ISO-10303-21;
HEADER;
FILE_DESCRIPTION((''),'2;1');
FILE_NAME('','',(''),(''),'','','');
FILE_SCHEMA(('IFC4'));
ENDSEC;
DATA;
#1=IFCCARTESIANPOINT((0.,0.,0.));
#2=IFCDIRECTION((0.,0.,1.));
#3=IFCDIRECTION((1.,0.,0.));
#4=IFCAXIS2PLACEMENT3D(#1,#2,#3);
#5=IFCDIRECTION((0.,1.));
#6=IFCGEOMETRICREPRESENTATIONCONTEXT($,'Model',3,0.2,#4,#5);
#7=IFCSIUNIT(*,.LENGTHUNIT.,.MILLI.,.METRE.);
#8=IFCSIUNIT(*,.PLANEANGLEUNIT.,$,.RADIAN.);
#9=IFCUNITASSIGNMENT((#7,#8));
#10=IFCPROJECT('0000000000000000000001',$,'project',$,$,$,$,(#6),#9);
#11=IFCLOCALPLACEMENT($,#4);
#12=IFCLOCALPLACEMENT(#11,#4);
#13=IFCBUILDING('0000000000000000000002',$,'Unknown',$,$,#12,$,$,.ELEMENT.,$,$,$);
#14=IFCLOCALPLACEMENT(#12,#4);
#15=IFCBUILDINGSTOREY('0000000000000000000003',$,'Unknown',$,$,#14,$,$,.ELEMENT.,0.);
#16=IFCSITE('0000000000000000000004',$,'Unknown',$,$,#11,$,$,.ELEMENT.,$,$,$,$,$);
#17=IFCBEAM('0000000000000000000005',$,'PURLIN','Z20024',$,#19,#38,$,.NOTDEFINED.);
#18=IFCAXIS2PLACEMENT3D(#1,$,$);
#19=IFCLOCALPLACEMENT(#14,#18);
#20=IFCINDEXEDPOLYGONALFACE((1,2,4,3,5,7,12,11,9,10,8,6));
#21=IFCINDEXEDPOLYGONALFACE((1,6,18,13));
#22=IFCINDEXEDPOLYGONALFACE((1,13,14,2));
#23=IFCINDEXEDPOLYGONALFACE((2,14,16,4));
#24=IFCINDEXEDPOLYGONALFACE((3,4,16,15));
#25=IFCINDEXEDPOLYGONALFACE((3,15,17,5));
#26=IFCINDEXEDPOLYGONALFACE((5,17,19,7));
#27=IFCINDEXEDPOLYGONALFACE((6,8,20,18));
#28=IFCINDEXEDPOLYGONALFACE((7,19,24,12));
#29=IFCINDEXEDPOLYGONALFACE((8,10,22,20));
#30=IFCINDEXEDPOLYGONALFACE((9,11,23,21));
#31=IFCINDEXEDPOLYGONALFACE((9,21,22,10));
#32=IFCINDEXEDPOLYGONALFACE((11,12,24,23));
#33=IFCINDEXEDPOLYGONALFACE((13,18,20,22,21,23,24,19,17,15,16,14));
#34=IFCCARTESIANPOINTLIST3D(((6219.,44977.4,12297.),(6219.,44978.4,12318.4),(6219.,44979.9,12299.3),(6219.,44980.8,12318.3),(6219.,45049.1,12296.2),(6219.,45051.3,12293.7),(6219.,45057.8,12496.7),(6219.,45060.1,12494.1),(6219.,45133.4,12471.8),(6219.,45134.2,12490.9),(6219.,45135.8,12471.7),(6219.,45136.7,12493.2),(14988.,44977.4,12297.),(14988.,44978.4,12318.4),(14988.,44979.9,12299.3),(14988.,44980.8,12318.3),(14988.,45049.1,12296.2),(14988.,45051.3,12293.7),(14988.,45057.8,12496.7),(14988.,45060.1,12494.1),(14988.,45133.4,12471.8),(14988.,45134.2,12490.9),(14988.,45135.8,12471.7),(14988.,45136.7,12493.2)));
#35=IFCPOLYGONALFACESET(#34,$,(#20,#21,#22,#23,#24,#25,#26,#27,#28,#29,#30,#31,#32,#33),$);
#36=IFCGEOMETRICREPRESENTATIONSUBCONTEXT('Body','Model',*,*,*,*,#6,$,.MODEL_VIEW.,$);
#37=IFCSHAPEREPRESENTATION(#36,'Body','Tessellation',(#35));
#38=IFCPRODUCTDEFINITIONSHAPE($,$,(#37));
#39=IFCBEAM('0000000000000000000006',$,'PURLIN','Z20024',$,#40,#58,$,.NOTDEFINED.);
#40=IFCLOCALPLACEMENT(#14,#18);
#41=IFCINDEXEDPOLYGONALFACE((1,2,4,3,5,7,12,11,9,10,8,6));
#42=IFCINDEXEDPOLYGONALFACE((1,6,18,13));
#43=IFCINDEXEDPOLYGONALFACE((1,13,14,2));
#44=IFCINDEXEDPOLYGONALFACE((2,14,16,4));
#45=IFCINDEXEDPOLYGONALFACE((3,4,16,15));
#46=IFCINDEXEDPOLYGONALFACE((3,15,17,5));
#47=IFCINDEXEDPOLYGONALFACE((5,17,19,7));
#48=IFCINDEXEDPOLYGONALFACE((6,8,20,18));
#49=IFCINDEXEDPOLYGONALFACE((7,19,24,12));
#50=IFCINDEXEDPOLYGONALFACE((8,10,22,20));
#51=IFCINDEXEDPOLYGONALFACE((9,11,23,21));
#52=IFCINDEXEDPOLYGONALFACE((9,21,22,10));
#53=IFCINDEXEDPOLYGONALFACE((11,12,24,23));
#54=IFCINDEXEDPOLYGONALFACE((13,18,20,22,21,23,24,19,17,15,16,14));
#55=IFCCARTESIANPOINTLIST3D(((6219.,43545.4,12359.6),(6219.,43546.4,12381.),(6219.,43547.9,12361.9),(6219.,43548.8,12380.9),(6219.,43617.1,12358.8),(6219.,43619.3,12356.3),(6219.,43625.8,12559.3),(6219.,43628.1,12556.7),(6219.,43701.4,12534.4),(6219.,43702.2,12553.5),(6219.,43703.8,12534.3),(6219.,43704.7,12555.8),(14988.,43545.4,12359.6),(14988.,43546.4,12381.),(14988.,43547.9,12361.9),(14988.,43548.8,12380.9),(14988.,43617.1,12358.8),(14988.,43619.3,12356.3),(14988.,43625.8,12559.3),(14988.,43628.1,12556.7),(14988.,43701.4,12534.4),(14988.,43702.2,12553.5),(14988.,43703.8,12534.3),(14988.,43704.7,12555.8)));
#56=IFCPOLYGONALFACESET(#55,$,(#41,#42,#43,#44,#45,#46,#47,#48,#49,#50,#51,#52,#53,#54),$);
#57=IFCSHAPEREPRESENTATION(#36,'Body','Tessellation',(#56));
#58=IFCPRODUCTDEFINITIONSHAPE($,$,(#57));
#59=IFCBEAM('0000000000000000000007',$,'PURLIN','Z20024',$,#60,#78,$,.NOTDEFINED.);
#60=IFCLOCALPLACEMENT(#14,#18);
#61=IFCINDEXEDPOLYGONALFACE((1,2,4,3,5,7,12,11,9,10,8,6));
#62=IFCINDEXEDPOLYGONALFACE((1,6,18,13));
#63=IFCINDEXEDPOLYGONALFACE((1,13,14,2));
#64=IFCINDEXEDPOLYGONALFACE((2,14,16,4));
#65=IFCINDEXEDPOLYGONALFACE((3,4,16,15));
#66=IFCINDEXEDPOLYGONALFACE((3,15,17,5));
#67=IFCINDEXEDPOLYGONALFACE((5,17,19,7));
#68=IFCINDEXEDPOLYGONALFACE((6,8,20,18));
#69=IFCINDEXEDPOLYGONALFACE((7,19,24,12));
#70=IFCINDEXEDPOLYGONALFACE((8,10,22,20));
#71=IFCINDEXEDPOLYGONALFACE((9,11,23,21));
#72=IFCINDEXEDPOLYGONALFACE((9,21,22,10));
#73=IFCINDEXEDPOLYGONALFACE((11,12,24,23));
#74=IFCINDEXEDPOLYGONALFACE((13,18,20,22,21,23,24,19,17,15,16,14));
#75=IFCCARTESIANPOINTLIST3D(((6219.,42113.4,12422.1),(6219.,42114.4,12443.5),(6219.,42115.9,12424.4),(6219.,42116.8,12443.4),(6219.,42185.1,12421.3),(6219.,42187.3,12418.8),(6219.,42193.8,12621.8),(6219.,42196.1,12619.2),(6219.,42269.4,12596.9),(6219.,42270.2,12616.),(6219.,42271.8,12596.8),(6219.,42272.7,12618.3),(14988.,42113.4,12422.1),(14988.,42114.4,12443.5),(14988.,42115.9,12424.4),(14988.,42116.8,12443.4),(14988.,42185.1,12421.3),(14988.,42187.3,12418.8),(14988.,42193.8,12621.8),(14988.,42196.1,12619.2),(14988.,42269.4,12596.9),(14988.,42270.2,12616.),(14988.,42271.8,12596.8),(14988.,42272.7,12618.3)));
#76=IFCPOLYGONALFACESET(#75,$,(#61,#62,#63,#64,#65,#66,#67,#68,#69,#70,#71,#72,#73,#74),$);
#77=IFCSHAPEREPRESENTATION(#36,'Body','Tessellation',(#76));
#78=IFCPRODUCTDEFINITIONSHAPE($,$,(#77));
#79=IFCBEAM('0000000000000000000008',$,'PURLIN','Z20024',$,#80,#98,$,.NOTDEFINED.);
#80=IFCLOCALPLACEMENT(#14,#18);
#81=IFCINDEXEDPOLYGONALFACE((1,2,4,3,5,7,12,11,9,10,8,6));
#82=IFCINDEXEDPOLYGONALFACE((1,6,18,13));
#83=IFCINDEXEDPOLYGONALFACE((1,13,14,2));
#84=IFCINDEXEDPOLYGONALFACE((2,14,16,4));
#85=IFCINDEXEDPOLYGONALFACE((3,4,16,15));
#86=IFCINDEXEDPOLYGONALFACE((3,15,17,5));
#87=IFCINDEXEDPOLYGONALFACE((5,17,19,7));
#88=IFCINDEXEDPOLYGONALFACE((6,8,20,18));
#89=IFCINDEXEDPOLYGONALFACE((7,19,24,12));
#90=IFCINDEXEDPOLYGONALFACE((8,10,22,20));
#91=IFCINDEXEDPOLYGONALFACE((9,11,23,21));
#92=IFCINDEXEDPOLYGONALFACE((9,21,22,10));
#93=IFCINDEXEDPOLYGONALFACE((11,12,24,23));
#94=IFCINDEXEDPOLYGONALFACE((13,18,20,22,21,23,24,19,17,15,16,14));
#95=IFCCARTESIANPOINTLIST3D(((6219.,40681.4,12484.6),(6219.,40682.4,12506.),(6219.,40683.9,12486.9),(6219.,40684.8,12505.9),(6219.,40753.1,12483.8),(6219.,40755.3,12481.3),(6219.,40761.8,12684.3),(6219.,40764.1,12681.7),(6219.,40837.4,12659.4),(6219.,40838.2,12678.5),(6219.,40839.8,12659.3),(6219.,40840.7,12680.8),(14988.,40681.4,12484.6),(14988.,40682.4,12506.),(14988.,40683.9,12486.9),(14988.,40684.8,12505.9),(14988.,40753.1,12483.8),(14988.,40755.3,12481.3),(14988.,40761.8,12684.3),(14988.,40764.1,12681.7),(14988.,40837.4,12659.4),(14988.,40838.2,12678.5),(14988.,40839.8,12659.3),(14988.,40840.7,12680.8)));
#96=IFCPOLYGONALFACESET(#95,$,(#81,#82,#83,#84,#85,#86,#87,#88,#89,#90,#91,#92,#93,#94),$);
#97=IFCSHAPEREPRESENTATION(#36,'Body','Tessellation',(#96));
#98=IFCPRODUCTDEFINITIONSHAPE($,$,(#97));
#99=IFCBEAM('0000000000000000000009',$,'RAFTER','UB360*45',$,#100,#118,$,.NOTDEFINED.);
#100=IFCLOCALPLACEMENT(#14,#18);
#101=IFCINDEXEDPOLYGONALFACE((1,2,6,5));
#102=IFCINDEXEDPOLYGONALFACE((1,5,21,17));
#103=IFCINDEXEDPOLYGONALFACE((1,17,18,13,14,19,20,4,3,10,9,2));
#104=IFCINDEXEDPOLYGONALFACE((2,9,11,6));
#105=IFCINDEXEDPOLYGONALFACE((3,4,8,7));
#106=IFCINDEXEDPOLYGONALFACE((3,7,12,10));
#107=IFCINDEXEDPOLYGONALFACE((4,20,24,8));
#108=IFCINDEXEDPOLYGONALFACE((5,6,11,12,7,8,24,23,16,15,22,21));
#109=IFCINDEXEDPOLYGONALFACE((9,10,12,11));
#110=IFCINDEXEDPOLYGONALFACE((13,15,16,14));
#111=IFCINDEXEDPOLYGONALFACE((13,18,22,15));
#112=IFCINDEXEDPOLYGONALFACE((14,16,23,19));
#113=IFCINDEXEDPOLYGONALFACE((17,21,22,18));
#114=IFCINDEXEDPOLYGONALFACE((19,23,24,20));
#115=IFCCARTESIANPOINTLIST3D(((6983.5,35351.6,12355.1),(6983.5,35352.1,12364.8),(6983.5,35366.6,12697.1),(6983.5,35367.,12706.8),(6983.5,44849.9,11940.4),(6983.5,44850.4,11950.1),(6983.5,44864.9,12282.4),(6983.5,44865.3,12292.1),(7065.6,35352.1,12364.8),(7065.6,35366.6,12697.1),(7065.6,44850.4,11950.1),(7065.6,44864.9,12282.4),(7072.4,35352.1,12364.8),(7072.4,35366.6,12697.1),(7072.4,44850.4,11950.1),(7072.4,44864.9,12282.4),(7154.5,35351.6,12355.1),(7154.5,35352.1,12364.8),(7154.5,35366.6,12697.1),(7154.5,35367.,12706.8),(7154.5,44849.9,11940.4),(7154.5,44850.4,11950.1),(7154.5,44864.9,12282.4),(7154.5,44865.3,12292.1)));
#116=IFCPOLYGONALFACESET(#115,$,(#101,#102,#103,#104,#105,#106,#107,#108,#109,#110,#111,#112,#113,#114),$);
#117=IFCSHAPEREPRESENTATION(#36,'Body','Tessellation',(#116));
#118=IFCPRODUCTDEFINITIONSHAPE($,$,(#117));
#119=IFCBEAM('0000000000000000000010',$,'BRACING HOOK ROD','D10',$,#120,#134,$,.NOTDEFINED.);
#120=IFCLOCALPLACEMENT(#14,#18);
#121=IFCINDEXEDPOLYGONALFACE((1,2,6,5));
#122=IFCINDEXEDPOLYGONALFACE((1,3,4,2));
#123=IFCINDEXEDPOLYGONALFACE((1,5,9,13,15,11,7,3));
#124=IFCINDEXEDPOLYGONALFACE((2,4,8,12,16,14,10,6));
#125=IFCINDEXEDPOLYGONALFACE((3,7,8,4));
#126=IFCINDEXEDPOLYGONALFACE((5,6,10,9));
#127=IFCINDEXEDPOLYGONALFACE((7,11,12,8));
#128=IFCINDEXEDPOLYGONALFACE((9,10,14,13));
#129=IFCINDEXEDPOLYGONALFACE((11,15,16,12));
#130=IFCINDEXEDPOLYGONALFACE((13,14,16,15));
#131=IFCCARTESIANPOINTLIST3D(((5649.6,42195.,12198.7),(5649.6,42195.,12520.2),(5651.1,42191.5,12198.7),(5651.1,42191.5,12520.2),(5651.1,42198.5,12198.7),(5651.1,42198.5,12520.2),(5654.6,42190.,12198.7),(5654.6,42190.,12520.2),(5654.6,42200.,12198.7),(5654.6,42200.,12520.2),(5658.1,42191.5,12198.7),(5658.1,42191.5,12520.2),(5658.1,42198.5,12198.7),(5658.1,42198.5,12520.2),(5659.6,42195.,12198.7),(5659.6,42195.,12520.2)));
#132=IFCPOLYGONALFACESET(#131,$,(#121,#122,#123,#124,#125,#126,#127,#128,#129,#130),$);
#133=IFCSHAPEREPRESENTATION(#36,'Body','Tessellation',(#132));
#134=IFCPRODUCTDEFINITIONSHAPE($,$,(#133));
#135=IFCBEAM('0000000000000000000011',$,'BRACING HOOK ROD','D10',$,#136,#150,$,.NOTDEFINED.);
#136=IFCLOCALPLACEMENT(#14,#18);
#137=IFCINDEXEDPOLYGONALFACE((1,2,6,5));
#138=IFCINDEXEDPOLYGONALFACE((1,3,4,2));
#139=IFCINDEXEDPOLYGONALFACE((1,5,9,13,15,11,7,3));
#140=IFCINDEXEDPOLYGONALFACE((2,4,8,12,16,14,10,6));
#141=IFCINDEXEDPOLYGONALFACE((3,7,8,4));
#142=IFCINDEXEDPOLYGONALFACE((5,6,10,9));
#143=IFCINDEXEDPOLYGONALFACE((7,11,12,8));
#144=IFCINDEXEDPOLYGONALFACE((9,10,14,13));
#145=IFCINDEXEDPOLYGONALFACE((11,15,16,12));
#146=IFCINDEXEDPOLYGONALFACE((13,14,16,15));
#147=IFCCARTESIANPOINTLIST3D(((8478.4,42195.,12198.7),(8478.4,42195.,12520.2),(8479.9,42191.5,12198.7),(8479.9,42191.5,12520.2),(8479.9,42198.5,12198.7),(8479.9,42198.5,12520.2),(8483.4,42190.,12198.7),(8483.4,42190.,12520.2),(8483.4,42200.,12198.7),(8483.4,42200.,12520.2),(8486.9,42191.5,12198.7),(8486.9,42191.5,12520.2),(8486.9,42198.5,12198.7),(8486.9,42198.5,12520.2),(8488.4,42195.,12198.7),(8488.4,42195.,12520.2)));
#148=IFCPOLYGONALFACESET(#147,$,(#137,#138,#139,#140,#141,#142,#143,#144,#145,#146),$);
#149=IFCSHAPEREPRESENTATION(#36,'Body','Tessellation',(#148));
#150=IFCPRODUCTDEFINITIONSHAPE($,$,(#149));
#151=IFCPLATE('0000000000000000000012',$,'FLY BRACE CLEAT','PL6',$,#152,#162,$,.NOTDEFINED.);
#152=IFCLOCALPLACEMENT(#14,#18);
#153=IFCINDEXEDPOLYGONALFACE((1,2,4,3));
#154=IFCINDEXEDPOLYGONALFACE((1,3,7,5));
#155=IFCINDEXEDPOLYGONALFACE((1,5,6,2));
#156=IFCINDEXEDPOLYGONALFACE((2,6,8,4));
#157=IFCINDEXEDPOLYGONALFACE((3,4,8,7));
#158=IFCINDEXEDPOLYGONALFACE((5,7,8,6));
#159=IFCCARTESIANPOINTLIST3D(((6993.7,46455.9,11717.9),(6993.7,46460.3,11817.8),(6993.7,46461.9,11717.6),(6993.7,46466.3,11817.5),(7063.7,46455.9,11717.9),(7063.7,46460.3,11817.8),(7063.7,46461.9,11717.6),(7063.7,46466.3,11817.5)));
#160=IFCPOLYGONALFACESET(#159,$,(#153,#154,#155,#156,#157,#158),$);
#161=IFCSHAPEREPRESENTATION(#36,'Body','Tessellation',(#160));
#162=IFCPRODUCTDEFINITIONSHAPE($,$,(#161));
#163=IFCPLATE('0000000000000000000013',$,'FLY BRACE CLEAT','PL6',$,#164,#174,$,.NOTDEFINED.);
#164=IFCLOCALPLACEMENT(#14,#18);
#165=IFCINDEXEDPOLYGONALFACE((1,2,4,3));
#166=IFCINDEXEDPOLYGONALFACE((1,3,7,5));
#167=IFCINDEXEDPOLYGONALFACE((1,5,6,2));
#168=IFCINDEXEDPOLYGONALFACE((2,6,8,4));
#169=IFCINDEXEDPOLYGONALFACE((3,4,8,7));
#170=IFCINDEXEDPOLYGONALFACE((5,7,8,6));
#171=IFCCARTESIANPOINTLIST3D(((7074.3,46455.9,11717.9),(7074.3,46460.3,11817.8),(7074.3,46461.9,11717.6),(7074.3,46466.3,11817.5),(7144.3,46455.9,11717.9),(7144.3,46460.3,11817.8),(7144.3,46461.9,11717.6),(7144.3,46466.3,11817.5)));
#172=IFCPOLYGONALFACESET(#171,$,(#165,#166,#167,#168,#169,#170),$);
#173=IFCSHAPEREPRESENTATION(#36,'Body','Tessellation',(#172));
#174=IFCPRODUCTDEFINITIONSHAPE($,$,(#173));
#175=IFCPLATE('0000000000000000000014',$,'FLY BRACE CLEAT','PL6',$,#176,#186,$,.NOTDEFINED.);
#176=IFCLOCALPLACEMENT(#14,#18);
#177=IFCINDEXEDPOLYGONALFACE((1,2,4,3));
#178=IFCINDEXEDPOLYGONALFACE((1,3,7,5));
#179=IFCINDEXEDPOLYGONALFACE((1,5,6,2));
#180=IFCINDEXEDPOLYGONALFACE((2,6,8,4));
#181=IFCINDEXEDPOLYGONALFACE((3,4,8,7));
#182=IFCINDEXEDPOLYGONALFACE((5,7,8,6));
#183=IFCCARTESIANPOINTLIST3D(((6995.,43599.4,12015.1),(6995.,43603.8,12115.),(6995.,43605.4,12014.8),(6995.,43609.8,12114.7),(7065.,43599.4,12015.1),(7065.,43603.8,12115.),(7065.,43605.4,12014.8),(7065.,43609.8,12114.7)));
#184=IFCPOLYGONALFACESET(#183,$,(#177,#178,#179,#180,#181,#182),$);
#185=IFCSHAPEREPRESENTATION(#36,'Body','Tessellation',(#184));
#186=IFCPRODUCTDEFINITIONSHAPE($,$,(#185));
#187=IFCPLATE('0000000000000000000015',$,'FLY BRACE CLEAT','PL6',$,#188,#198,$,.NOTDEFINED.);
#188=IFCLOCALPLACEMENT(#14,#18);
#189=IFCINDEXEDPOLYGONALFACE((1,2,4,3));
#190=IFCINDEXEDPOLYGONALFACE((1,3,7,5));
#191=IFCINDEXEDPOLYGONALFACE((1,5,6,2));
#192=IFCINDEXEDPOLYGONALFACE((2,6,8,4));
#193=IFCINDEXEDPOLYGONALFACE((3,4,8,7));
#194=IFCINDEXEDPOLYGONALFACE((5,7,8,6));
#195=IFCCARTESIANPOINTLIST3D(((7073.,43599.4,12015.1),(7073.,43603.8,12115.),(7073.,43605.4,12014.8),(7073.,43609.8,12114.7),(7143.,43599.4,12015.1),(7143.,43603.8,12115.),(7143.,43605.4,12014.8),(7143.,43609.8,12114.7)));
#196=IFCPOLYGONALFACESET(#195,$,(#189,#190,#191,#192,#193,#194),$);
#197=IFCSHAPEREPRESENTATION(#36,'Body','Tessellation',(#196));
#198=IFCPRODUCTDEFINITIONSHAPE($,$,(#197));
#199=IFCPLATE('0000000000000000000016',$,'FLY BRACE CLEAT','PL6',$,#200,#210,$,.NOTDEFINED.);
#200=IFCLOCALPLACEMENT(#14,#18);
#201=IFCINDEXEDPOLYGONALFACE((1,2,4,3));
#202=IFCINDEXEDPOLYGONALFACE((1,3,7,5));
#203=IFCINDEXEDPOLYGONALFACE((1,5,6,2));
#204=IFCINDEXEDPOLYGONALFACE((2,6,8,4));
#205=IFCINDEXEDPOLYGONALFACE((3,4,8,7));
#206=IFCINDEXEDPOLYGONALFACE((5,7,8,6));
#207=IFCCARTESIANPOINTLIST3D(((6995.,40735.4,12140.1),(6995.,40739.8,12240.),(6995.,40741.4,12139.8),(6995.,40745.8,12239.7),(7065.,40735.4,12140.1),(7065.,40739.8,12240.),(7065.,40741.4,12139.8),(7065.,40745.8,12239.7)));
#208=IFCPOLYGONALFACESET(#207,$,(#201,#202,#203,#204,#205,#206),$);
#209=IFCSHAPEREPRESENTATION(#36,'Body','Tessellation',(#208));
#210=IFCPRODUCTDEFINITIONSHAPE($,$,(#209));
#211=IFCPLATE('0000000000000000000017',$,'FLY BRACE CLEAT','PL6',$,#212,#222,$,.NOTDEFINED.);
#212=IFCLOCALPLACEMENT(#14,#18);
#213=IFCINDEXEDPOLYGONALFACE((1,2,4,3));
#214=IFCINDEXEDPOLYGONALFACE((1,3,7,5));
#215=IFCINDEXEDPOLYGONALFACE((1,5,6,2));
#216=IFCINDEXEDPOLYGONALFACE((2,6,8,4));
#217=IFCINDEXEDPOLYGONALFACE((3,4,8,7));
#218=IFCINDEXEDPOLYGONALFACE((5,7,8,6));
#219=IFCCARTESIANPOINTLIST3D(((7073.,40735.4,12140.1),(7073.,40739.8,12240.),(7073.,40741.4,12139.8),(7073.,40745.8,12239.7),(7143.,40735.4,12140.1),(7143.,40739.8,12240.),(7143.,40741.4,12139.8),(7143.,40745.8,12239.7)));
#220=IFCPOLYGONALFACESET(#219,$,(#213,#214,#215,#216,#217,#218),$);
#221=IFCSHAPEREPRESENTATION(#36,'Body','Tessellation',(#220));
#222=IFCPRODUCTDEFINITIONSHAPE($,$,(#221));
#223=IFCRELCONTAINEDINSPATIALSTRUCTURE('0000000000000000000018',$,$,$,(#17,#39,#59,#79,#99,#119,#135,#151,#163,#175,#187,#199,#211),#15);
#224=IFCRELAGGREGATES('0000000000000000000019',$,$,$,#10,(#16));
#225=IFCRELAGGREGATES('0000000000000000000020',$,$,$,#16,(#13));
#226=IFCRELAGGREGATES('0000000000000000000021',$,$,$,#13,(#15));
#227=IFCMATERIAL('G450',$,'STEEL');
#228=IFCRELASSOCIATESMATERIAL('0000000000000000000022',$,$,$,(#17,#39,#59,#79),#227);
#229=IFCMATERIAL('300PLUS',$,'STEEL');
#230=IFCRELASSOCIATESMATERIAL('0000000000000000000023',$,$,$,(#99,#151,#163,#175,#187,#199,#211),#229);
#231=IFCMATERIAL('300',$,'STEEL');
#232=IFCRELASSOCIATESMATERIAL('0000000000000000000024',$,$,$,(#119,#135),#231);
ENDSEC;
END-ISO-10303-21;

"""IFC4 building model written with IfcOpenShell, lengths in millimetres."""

from ifc_helpers import new_model, si_unit, direction, frame, origin_with_axes, place, context, subcontext, project, spatial, line, indexed_curve, outline, extrude, material, element, save


model = new_model("IFC4")

# Units and contexts
model_context = context("Model", 3, precision=0.2, world=origin_with_axes(), true_north=direction((0.0, 1.0)))
body_context = subcontext(model_context, "Body", "Model", "MODEL_VIEW")
ifc_project = project(units=[si_unit("LENGTHUNIT", "METRE", prefix="MILLI"), si_unit("PLANEANGLEUNIT", "RADIAN")], contexts=[model_context])

# Site, building, storey
site_placement = place(None, origin_with_axes())
site = spatial("IfcSite", under=ifc_project, at=site_placement, Name="Unknown", CompositionType="ELEMENT")
building_placement = place(site_placement, origin_with_axes())
building = spatial("IfcBuilding", under=site, at=building_placement, Name="Unknown", CompositionType="ELEMENT")
storey_placement = place(building_placement, origin_with_axes())
storey = spatial("IfcBuildingStorey", under=building, at=storey_placement, Name="Unknown", CompositionType="ELEMENT", Elevation=0.0)

# Shared definitions
ifc_material_1 = material(Name="300PLUS", Category="STEEL")

# Beams
ifc_material_2 = material(Name="G450", Category="STEEL")
for number, where, z_axis, x_axis, name in (
    (1, (6219.0, 45054.6, 12395.2), (0.0, -0.999048, 0.043619), (1.0, 0.0, 0.0), "PURLIN"),
    (2, (6219.0, 43622.6, 12457.8), (0.0, -0.999048, 0.043619), (1.0, 0.0, 0.0), "PURLIN"),
    (3, (6219.0, 42190.6, 12520.3), (0.0, -0.999048, 0.043619), (1.0, 0.0, 0.0), "PURLIN"),
    (4, (6219.0, 40758.6, 12582.8), (0.0, -0.999048, 0.043619), (1.0, 0.0, 0.0), "PURLIN"),
):
    element("IfcBeam", number, at=place(storey_placement, frame(where, z_axis=z_axis, x_axis=x_axis)), inside=storey, material=ifc_material_2, Name=name, Description="Z20024", PredefinedType="NOTDEFINED", context=body_context, shape_type="SolidModel", body=[
        extrude(outline(indexed_curve([(72.8, -101.5), (72.8, -80.0), (70.4, -80.0), (70.4, -99.1), (1.2, -99.1), (1.2, 101.5), (-77.8, 101.5), (-77.8, 80.0), (-75.4, 80.0), (-75.4, 99.1), (-1.2, 99.1), (-1.2, -101.5)], segments=[line(1, 2, 3, 4, 5, 6, 7, 8, 9, 10, 11, 12, 1)])), frame((0.0, 0.0, 0.0), z_axis=(-1.0, 0.0, 0.0), x_axis=(0.0, 0.0, 1.0)), (0.0, 0.0, -1.0), 8769.0),
    ])
beam_1_placement = place(storey_placement, frame((7069.0, 44857.6, 12116.3), z_axis=(-1.0, 0.0, 0.0), x_axis=(0.0, -0.999048, 0.043619)))
element("IfcBeam", 5, at=beam_1_placement, inside=storey, material=ifc_material_1, Name="RAFTER", Description="UB360*45", PredefinedType="NOTDEFINED", context=body_context, shape_type="SolidModel", body=[
    extrude(outline(indexed_curve([(-85.5, -176.0), (85.5, -176.0), (85.5, -166.3), (3.5, -166.3), (3.5, 166.3), (85.5, 166.3), (85.5, 176.0), (-85.5, 176.0), (-85.5, 166.3), (-3.5, 166.3), (-3.5, -166.3), (-85.5, -166.3)], segments=[line(1, 2, 3, 4, 5, 6, 7, 8, 9, 10, 11, 12, 1)])), frame((0.0, 0.0, 0.0), z_axis=(-1.0, 0.0, 0.0), x_axis=(0.0, 0.0, 1.0)), (0.0, 0.0, -1.0), 9507.3),
])
ifc_material_3 = material(Name="300", Category="STEEL")
for number, where, z_axis, x_axis, name in (
    (6, (5654.6, 42195.0, 12520.2), (1.0, 0.0, 0.0), (0.0, 0.0, -1.0), "BRACING HOOK ROD"),
    (7, (8483.4, 42195.0, 12520.2), (1.0, 0.0, 0.0), (0.0, 0.0, -1.0), "BRACING HOOK ROD"),
):
    element("IfcBeam", number, at=place(storey_placement, frame(where, z_axis=z_axis, x_axis=x_axis)), inside=storey, material=ifc_material_3, Name=name, Description="D10", PredefinedType="NOTDEFINED", context=body_context, shape_type="SolidModel", body=[
        extrude(outline(indexed_curve([(5.0, 0.0), (3.5, 3.5), (0.0, 5.0), (-3.5, 3.5), (-5.0, 0.0), (-3.5, -3.5), (0.0, -5.0), (3.5, -3.5)], segments=[line(1, 2, 3, 4, 5, 6, 7, 8, 1)])), frame((0.0, 0.0, 0.0), z_axis=(-1.0, 0.0, 0.0), x_axis=(0.0, 0.0, 1.0)), (0.0, 0.0, -1.0), 321.5),
    ])

# Plates
for number, where, z_axis, x_axis, name in (
    (8, (6993.7, 46458.9, 11717.7), (0.0, -0.999031, 0.044001), (1.0, 0.0, 0.0), "FLY BRACE CLEAT"),
    (9, (7074.3, 46458.9, 11717.7), (0.0, -0.999031, 0.044001), (1.0, 0.0, 0.0), "FLY BRACE CLEAT"),
    (10, (7065.0, 43606.8, 12114.8), (0.0, -0.999031, 0.044001), (-1.0, 0.0, 0.0), "FLY BRACE CLEAT"),
    (11, (7143.0, 43606.8, 12114.8), (0.0, -0.999031, 0.044001), (-1.0, 0.0, 0.0), "FLY BRACE CLEAT"),
    (12, (7065.0, 40742.8, 12239.8), (0.0, -0.999031, 0.044001), (-1.0, 0.0, 0.0), "FLY BRACE CLEAT"),
    (13, (7143.0, 40742.8, 12239.8), (0.0, -0.999031, 0.044001), (-1.0, 0.0, 0.0), "FLY BRACE CLEAT"),
):
    element("IfcPlate", number, at=place(storey_placement, frame(where, z_axis=z_axis, x_axis=x_axis)), inside=storey, material=ifc_material_1, Name=name, Description="PL6", PredefinedType="NOTDEFINED", context=body_context, shape_type="SolidModel", body=[
        extrude(outline(indexed_curve([(0.0, 0.0), (70.0, 0.0), (70.0, 100.0), (0.0, 100.0)], segments=[line(1, 2, 3, 4, 1)])), frame((0.0, 0.0, 3.0), z_axis=(0.0, 0.0, 1.0), x_axis=(1.0, 0.0, 0.0)), (0.0, 0.0, -1.0), 6.0),
    ])

save(model, "model.ifc")
